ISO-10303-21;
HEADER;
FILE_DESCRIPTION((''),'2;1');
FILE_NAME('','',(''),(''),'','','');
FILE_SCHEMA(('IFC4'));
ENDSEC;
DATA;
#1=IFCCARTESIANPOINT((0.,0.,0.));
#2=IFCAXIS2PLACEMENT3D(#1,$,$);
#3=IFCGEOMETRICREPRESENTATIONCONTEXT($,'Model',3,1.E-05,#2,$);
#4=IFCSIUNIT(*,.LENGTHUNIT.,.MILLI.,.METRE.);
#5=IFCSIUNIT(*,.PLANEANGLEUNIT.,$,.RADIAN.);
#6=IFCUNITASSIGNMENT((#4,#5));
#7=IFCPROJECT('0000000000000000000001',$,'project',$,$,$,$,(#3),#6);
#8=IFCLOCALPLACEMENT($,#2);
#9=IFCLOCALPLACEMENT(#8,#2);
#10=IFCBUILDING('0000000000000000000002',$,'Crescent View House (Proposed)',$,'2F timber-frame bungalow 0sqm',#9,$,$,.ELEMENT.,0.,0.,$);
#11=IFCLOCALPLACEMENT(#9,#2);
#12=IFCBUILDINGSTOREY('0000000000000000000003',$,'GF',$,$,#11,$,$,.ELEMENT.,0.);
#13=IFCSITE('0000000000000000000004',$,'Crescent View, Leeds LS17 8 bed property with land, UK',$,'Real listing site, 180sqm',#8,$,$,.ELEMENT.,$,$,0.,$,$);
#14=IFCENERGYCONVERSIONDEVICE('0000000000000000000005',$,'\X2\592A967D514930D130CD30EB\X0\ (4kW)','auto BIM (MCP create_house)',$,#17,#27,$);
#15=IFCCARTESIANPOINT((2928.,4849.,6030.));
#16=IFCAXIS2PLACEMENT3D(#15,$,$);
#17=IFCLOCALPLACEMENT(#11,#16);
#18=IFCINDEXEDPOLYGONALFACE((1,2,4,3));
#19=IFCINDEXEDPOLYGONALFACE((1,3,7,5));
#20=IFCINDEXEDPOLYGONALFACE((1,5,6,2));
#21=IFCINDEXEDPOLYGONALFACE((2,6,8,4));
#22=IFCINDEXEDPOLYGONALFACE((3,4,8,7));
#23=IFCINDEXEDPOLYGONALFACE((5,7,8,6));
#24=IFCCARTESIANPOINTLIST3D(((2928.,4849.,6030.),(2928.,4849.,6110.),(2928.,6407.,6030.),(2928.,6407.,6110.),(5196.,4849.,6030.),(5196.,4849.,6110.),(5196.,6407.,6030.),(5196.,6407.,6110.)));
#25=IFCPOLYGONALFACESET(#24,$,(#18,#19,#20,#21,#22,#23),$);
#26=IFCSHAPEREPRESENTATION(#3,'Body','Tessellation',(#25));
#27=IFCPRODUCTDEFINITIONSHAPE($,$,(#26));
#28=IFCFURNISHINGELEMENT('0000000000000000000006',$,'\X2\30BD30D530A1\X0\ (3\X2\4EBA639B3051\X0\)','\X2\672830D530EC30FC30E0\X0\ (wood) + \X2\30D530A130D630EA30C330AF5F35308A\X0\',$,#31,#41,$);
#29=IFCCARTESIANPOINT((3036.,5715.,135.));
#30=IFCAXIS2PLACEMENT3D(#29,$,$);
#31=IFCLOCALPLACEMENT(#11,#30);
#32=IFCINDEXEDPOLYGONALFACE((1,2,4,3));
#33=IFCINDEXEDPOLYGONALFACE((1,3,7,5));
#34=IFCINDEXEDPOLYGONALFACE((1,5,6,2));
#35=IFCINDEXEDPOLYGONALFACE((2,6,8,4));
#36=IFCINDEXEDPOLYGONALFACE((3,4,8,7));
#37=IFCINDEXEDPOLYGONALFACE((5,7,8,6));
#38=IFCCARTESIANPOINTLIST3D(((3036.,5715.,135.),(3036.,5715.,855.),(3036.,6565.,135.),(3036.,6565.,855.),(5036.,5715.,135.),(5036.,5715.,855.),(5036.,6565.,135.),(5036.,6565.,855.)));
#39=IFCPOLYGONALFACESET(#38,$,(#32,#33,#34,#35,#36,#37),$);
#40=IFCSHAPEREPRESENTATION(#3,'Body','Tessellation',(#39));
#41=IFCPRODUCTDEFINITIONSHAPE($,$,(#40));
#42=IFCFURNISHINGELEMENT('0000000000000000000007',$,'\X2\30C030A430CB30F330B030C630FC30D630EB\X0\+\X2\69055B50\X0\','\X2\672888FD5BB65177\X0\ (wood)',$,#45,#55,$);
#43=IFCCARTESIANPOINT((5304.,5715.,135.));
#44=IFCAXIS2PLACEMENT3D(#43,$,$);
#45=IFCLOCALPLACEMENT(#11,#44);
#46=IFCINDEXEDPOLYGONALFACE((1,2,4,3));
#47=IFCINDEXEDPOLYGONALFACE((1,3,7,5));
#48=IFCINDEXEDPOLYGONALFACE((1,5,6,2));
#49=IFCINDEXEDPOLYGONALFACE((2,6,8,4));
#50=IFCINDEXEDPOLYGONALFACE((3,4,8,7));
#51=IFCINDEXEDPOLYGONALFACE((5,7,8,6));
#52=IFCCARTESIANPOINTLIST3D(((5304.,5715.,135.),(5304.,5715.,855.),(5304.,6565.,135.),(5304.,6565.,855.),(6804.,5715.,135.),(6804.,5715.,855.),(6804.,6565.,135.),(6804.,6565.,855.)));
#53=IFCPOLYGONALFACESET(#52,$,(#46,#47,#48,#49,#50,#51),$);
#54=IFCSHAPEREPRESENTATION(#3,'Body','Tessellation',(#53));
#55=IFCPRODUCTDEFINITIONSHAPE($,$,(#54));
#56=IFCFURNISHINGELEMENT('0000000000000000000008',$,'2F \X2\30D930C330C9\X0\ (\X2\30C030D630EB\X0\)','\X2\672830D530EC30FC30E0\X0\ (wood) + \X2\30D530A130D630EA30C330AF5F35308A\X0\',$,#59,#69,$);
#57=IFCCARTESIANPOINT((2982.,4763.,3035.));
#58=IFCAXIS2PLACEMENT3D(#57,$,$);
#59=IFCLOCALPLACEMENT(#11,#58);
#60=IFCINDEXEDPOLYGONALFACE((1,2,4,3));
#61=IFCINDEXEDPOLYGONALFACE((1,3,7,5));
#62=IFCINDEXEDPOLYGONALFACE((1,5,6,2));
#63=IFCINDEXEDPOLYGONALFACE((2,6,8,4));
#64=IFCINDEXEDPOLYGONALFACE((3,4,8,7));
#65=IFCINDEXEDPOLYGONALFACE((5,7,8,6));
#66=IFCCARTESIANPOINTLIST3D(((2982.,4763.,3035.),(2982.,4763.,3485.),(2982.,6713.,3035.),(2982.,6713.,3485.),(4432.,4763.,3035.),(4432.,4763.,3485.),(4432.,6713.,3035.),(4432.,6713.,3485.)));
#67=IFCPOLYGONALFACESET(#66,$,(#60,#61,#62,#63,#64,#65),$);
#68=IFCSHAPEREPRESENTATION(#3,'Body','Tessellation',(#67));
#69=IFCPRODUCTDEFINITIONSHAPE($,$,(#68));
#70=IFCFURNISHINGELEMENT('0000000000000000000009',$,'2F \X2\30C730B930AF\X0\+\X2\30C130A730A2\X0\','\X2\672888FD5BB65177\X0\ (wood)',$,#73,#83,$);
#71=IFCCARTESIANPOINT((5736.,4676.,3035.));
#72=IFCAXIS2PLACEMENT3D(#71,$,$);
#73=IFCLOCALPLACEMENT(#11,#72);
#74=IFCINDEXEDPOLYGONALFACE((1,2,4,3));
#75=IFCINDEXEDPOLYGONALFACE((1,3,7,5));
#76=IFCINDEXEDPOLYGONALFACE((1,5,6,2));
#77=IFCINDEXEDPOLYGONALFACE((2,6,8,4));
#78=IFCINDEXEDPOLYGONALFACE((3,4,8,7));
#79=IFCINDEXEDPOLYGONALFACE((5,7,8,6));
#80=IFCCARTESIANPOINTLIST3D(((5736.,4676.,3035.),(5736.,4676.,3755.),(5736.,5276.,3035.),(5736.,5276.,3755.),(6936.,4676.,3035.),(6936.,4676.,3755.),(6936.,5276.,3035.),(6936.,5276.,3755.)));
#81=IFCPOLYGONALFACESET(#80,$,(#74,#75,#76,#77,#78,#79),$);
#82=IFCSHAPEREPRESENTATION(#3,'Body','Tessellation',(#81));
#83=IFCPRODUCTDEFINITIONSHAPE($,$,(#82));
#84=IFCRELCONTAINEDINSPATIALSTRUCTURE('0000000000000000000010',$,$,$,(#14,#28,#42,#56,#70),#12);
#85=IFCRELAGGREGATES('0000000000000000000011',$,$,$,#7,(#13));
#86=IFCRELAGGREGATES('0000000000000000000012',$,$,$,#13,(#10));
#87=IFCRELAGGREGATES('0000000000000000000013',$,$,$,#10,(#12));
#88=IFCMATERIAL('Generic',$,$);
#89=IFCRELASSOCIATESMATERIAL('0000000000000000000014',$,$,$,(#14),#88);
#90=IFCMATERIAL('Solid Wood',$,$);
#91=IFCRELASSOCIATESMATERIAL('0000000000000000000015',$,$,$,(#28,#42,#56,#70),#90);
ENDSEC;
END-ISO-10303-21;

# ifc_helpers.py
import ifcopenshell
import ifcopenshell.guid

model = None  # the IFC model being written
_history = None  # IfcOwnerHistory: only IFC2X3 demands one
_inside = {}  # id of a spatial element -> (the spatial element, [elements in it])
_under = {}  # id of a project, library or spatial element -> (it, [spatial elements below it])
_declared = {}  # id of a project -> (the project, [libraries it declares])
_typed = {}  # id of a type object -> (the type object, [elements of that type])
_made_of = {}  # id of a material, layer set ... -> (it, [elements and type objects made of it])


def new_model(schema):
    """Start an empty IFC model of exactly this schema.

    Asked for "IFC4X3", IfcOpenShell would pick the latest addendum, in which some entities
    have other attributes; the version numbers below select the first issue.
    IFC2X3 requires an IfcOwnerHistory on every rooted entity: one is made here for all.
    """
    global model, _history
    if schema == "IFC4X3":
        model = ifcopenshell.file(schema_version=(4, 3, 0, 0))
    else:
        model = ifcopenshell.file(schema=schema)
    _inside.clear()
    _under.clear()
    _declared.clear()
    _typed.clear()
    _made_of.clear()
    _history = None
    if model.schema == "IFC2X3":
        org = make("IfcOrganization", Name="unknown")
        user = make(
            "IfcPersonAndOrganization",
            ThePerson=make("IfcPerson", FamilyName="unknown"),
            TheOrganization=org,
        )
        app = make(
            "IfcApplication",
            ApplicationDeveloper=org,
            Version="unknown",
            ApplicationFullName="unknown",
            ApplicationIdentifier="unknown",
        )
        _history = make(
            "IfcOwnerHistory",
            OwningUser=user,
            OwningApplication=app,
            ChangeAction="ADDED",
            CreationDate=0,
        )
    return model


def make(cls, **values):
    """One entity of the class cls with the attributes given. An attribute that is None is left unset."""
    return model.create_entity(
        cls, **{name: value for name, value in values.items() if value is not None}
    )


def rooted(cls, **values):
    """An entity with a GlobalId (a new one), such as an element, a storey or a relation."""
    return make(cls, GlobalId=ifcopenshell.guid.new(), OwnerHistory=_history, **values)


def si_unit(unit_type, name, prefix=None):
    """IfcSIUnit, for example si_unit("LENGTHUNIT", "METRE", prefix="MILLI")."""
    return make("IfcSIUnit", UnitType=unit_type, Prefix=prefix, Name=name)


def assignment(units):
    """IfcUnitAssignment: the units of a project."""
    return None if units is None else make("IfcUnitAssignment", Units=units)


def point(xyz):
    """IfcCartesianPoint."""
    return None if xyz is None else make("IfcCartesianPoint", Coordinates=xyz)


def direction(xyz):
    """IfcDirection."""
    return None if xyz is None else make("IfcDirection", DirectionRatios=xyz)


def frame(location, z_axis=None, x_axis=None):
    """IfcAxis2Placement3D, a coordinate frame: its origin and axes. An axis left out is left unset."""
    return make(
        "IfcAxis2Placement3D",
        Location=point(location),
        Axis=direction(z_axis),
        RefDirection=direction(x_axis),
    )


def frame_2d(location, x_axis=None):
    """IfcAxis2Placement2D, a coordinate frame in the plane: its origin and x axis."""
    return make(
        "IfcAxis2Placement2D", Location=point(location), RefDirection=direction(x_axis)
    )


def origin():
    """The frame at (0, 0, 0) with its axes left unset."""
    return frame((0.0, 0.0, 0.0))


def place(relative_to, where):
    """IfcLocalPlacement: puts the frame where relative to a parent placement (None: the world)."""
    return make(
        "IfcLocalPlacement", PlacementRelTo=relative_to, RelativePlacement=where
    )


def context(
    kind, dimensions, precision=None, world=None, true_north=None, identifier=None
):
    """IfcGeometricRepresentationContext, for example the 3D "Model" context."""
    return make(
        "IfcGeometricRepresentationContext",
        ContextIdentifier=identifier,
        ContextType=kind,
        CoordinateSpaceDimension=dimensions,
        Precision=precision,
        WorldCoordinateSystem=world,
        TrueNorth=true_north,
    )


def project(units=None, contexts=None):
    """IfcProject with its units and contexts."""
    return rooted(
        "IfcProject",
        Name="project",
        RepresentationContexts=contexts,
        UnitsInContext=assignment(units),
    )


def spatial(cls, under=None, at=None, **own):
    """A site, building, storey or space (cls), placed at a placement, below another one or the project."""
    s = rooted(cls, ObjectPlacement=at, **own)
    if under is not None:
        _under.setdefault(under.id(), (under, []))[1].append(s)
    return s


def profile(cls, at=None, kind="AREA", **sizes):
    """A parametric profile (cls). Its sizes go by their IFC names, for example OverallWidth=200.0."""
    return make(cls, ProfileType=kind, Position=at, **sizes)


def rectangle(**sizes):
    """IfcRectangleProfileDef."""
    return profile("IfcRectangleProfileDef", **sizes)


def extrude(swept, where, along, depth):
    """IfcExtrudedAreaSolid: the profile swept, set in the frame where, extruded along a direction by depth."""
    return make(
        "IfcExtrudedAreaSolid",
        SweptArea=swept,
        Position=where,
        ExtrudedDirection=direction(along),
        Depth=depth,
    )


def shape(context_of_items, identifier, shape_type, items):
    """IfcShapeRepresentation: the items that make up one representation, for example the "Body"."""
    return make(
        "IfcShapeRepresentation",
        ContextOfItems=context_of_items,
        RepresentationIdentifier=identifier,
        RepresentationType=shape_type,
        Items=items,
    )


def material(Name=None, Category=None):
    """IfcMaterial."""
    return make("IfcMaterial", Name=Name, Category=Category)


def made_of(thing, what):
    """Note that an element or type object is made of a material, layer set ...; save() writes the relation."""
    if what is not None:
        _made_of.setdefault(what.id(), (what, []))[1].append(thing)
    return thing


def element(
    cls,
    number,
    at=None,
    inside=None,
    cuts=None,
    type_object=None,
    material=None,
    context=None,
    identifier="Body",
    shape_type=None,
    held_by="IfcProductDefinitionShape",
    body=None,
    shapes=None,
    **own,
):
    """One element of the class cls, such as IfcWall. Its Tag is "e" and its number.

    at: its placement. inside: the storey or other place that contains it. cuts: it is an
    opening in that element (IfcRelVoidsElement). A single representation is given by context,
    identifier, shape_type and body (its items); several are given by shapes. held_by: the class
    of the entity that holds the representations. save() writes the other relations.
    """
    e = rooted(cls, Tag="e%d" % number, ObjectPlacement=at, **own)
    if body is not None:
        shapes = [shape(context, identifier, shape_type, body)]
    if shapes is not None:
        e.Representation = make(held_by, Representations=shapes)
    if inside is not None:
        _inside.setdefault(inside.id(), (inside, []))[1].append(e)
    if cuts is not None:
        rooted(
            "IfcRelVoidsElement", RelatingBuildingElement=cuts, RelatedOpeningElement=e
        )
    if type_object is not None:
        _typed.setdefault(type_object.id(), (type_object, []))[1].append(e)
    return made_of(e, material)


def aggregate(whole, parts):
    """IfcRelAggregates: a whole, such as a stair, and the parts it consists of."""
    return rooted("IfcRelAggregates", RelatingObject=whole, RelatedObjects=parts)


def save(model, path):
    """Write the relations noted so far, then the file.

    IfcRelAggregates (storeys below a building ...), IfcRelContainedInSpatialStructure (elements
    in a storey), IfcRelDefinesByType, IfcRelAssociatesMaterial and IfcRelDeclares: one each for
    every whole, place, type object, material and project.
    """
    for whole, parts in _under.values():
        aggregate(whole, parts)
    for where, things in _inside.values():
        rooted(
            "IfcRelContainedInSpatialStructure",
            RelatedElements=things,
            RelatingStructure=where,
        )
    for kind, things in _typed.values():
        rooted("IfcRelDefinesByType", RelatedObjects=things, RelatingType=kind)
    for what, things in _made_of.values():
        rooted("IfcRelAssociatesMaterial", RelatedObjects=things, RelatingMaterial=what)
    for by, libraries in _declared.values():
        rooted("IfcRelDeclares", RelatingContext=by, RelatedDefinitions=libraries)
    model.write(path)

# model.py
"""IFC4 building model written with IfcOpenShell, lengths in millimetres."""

from ifc_helpers import new_model, si_unit, frame, frame_2d, origin, place, context, project, spatial, rectangle, extrude, material, element, save


model = new_model("IFC4")

# Units and contexts
model_context = context("Model", 3, precision=1e-05, world=origin())
ifc_project = project(units=[si_unit("LENGTHUNIT", "METRE", prefix="MILLI"), si_unit("PLANEANGLEUNIT", "RADIAN")], contexts=[model_context])

# Site, building, storey
site_placement = place(None, origin())
site = spatial("IfcSite", under=ifc_project, at=site_placement, Name="Crescent View, Leeds LS17 8 bed property with land, UK", ObjectType="Real listing site, 180sqm", CompositionType="ELEMENT", RefElevation=0.0)
building_placement = place(site_placement, origin())
building = spatial("IfcBuilding", under=site, at=building_placement, Name="Crescent View House (Proposed)", ObjectType="2F timber-frame bungalow 0sqm", CompositionType="ELEMENT", ElevationOfRefHeight=0.0, ElevationOfTerrain=0.0)
storey_placement = place(building_placement, origin())
storey = spatial("IfcBuildingStorey", under=building, at=storey_placement, Name="GF", CompositionType="ELEMENT", Elevation=0.0)

# Shared definitions
ifc_material_1 = material(Name="Solid Wood")

# Shared definitions
ifc_material_2 = material(Name="Generic")

# Energy conversion device
energy_conversion_device_placement = place(storey_placement, frame((2928.0, 4849.0, 6030.0)))
element("IfcEnergyConversionDevice", 1, at=energy_conversion_device_placement, inside=storey, material=ifc_material_2, Name="太陽光パネル (4kW)", Description="auto BIM (MCP create_house)", context=model_context, shape_type="SweptSolid", body=[
    extrude(rectangle(XDim=2268.0, YDim=1558.0, at=frame_2d((1134.0, 779.0))), frame((2928.0, 4849.0, 6030.0)), (0.0, 0.0, 1.0), 80.0),
])

# Furnishing elements
furnishing_1_placement = place(storey_placement, frame((3036.0, 5715.0, 135.0)))
element("IfcFurnishingElement", 2, at=furnishing_1_placement, inside=storey, material=ifc_material_1, Name="ソファ (3人掛け)", Description="木フレーム (wood) + ファブリック張り", context=model_context, shape_type="SweptSolid", body=[
    extrude(rectangle(XDim=2000.0, YDim=850.0, at=frame_2d((1000.0, 425.0))), frame((3036.0, 5715.0, 135.0)), (0.0, 0.0, 1.0), 720.0),
])
furnishing_2_placement = place(storey_placement, frame((5304.0, 5715.0, 135.0)))
element("IfcFurnishingElement", 3, at=furnishing_2_placement, inside=storey, material=ifc_material_1, Name="ダイニングテーブル+椅子", Description="木製家具 (wood)", context=model_context, shape_type="SweptSolid", body=[
    extrude(rectangle(XDim=1500.0, YDim=850.0, at=frame_2d((750.0, 425.0))), frame((5304.0, 5715.0, 135.0)), (0.0, 0.0, 1.0), 720.0),
])
furnishing_3_placement = place(storey_placement, frame((2982.0, 4763.0, 3035.0)))
element("IfcFurnishingElement", 4, at=furnishing_3_placement, inside=storey, material=ifc_material_1, Name="2F ベッド (ダブル)", Description="木フレーム (wood) + ファブリック張り", context=model_context, shape_type="SweptSolid", body=[
    extrude(rectangle(XDim=1450.0, YDim=1950.0, at=frame_2d((725.0, 975.0))), frame((2982.0, 4763.0, 3035.0)), (0.0, 0.0, 1.0), 450.0),
])
furnishing_4_placement = place(storey_placement, frame((5736.0, 4676.0, 3035.0)))
element("IfcFurnishingElement", 5, at=furnishing_4_placement, inside=storey, material=ifc_material_1, Name="2F デスク+チェア", Description="木製家具 (wood)", context=model_context, shape_type="SweptSolid", body=[
    extrude(rectangle(XDim=1200.0, YDim=600.0, at=frame_2d((600.0, 300.0))), frame((5736.0, 4676.0, 3035.0)), (0.0, 0.0, 1.0), 720.0),
])

save(model, "model.ifc")
